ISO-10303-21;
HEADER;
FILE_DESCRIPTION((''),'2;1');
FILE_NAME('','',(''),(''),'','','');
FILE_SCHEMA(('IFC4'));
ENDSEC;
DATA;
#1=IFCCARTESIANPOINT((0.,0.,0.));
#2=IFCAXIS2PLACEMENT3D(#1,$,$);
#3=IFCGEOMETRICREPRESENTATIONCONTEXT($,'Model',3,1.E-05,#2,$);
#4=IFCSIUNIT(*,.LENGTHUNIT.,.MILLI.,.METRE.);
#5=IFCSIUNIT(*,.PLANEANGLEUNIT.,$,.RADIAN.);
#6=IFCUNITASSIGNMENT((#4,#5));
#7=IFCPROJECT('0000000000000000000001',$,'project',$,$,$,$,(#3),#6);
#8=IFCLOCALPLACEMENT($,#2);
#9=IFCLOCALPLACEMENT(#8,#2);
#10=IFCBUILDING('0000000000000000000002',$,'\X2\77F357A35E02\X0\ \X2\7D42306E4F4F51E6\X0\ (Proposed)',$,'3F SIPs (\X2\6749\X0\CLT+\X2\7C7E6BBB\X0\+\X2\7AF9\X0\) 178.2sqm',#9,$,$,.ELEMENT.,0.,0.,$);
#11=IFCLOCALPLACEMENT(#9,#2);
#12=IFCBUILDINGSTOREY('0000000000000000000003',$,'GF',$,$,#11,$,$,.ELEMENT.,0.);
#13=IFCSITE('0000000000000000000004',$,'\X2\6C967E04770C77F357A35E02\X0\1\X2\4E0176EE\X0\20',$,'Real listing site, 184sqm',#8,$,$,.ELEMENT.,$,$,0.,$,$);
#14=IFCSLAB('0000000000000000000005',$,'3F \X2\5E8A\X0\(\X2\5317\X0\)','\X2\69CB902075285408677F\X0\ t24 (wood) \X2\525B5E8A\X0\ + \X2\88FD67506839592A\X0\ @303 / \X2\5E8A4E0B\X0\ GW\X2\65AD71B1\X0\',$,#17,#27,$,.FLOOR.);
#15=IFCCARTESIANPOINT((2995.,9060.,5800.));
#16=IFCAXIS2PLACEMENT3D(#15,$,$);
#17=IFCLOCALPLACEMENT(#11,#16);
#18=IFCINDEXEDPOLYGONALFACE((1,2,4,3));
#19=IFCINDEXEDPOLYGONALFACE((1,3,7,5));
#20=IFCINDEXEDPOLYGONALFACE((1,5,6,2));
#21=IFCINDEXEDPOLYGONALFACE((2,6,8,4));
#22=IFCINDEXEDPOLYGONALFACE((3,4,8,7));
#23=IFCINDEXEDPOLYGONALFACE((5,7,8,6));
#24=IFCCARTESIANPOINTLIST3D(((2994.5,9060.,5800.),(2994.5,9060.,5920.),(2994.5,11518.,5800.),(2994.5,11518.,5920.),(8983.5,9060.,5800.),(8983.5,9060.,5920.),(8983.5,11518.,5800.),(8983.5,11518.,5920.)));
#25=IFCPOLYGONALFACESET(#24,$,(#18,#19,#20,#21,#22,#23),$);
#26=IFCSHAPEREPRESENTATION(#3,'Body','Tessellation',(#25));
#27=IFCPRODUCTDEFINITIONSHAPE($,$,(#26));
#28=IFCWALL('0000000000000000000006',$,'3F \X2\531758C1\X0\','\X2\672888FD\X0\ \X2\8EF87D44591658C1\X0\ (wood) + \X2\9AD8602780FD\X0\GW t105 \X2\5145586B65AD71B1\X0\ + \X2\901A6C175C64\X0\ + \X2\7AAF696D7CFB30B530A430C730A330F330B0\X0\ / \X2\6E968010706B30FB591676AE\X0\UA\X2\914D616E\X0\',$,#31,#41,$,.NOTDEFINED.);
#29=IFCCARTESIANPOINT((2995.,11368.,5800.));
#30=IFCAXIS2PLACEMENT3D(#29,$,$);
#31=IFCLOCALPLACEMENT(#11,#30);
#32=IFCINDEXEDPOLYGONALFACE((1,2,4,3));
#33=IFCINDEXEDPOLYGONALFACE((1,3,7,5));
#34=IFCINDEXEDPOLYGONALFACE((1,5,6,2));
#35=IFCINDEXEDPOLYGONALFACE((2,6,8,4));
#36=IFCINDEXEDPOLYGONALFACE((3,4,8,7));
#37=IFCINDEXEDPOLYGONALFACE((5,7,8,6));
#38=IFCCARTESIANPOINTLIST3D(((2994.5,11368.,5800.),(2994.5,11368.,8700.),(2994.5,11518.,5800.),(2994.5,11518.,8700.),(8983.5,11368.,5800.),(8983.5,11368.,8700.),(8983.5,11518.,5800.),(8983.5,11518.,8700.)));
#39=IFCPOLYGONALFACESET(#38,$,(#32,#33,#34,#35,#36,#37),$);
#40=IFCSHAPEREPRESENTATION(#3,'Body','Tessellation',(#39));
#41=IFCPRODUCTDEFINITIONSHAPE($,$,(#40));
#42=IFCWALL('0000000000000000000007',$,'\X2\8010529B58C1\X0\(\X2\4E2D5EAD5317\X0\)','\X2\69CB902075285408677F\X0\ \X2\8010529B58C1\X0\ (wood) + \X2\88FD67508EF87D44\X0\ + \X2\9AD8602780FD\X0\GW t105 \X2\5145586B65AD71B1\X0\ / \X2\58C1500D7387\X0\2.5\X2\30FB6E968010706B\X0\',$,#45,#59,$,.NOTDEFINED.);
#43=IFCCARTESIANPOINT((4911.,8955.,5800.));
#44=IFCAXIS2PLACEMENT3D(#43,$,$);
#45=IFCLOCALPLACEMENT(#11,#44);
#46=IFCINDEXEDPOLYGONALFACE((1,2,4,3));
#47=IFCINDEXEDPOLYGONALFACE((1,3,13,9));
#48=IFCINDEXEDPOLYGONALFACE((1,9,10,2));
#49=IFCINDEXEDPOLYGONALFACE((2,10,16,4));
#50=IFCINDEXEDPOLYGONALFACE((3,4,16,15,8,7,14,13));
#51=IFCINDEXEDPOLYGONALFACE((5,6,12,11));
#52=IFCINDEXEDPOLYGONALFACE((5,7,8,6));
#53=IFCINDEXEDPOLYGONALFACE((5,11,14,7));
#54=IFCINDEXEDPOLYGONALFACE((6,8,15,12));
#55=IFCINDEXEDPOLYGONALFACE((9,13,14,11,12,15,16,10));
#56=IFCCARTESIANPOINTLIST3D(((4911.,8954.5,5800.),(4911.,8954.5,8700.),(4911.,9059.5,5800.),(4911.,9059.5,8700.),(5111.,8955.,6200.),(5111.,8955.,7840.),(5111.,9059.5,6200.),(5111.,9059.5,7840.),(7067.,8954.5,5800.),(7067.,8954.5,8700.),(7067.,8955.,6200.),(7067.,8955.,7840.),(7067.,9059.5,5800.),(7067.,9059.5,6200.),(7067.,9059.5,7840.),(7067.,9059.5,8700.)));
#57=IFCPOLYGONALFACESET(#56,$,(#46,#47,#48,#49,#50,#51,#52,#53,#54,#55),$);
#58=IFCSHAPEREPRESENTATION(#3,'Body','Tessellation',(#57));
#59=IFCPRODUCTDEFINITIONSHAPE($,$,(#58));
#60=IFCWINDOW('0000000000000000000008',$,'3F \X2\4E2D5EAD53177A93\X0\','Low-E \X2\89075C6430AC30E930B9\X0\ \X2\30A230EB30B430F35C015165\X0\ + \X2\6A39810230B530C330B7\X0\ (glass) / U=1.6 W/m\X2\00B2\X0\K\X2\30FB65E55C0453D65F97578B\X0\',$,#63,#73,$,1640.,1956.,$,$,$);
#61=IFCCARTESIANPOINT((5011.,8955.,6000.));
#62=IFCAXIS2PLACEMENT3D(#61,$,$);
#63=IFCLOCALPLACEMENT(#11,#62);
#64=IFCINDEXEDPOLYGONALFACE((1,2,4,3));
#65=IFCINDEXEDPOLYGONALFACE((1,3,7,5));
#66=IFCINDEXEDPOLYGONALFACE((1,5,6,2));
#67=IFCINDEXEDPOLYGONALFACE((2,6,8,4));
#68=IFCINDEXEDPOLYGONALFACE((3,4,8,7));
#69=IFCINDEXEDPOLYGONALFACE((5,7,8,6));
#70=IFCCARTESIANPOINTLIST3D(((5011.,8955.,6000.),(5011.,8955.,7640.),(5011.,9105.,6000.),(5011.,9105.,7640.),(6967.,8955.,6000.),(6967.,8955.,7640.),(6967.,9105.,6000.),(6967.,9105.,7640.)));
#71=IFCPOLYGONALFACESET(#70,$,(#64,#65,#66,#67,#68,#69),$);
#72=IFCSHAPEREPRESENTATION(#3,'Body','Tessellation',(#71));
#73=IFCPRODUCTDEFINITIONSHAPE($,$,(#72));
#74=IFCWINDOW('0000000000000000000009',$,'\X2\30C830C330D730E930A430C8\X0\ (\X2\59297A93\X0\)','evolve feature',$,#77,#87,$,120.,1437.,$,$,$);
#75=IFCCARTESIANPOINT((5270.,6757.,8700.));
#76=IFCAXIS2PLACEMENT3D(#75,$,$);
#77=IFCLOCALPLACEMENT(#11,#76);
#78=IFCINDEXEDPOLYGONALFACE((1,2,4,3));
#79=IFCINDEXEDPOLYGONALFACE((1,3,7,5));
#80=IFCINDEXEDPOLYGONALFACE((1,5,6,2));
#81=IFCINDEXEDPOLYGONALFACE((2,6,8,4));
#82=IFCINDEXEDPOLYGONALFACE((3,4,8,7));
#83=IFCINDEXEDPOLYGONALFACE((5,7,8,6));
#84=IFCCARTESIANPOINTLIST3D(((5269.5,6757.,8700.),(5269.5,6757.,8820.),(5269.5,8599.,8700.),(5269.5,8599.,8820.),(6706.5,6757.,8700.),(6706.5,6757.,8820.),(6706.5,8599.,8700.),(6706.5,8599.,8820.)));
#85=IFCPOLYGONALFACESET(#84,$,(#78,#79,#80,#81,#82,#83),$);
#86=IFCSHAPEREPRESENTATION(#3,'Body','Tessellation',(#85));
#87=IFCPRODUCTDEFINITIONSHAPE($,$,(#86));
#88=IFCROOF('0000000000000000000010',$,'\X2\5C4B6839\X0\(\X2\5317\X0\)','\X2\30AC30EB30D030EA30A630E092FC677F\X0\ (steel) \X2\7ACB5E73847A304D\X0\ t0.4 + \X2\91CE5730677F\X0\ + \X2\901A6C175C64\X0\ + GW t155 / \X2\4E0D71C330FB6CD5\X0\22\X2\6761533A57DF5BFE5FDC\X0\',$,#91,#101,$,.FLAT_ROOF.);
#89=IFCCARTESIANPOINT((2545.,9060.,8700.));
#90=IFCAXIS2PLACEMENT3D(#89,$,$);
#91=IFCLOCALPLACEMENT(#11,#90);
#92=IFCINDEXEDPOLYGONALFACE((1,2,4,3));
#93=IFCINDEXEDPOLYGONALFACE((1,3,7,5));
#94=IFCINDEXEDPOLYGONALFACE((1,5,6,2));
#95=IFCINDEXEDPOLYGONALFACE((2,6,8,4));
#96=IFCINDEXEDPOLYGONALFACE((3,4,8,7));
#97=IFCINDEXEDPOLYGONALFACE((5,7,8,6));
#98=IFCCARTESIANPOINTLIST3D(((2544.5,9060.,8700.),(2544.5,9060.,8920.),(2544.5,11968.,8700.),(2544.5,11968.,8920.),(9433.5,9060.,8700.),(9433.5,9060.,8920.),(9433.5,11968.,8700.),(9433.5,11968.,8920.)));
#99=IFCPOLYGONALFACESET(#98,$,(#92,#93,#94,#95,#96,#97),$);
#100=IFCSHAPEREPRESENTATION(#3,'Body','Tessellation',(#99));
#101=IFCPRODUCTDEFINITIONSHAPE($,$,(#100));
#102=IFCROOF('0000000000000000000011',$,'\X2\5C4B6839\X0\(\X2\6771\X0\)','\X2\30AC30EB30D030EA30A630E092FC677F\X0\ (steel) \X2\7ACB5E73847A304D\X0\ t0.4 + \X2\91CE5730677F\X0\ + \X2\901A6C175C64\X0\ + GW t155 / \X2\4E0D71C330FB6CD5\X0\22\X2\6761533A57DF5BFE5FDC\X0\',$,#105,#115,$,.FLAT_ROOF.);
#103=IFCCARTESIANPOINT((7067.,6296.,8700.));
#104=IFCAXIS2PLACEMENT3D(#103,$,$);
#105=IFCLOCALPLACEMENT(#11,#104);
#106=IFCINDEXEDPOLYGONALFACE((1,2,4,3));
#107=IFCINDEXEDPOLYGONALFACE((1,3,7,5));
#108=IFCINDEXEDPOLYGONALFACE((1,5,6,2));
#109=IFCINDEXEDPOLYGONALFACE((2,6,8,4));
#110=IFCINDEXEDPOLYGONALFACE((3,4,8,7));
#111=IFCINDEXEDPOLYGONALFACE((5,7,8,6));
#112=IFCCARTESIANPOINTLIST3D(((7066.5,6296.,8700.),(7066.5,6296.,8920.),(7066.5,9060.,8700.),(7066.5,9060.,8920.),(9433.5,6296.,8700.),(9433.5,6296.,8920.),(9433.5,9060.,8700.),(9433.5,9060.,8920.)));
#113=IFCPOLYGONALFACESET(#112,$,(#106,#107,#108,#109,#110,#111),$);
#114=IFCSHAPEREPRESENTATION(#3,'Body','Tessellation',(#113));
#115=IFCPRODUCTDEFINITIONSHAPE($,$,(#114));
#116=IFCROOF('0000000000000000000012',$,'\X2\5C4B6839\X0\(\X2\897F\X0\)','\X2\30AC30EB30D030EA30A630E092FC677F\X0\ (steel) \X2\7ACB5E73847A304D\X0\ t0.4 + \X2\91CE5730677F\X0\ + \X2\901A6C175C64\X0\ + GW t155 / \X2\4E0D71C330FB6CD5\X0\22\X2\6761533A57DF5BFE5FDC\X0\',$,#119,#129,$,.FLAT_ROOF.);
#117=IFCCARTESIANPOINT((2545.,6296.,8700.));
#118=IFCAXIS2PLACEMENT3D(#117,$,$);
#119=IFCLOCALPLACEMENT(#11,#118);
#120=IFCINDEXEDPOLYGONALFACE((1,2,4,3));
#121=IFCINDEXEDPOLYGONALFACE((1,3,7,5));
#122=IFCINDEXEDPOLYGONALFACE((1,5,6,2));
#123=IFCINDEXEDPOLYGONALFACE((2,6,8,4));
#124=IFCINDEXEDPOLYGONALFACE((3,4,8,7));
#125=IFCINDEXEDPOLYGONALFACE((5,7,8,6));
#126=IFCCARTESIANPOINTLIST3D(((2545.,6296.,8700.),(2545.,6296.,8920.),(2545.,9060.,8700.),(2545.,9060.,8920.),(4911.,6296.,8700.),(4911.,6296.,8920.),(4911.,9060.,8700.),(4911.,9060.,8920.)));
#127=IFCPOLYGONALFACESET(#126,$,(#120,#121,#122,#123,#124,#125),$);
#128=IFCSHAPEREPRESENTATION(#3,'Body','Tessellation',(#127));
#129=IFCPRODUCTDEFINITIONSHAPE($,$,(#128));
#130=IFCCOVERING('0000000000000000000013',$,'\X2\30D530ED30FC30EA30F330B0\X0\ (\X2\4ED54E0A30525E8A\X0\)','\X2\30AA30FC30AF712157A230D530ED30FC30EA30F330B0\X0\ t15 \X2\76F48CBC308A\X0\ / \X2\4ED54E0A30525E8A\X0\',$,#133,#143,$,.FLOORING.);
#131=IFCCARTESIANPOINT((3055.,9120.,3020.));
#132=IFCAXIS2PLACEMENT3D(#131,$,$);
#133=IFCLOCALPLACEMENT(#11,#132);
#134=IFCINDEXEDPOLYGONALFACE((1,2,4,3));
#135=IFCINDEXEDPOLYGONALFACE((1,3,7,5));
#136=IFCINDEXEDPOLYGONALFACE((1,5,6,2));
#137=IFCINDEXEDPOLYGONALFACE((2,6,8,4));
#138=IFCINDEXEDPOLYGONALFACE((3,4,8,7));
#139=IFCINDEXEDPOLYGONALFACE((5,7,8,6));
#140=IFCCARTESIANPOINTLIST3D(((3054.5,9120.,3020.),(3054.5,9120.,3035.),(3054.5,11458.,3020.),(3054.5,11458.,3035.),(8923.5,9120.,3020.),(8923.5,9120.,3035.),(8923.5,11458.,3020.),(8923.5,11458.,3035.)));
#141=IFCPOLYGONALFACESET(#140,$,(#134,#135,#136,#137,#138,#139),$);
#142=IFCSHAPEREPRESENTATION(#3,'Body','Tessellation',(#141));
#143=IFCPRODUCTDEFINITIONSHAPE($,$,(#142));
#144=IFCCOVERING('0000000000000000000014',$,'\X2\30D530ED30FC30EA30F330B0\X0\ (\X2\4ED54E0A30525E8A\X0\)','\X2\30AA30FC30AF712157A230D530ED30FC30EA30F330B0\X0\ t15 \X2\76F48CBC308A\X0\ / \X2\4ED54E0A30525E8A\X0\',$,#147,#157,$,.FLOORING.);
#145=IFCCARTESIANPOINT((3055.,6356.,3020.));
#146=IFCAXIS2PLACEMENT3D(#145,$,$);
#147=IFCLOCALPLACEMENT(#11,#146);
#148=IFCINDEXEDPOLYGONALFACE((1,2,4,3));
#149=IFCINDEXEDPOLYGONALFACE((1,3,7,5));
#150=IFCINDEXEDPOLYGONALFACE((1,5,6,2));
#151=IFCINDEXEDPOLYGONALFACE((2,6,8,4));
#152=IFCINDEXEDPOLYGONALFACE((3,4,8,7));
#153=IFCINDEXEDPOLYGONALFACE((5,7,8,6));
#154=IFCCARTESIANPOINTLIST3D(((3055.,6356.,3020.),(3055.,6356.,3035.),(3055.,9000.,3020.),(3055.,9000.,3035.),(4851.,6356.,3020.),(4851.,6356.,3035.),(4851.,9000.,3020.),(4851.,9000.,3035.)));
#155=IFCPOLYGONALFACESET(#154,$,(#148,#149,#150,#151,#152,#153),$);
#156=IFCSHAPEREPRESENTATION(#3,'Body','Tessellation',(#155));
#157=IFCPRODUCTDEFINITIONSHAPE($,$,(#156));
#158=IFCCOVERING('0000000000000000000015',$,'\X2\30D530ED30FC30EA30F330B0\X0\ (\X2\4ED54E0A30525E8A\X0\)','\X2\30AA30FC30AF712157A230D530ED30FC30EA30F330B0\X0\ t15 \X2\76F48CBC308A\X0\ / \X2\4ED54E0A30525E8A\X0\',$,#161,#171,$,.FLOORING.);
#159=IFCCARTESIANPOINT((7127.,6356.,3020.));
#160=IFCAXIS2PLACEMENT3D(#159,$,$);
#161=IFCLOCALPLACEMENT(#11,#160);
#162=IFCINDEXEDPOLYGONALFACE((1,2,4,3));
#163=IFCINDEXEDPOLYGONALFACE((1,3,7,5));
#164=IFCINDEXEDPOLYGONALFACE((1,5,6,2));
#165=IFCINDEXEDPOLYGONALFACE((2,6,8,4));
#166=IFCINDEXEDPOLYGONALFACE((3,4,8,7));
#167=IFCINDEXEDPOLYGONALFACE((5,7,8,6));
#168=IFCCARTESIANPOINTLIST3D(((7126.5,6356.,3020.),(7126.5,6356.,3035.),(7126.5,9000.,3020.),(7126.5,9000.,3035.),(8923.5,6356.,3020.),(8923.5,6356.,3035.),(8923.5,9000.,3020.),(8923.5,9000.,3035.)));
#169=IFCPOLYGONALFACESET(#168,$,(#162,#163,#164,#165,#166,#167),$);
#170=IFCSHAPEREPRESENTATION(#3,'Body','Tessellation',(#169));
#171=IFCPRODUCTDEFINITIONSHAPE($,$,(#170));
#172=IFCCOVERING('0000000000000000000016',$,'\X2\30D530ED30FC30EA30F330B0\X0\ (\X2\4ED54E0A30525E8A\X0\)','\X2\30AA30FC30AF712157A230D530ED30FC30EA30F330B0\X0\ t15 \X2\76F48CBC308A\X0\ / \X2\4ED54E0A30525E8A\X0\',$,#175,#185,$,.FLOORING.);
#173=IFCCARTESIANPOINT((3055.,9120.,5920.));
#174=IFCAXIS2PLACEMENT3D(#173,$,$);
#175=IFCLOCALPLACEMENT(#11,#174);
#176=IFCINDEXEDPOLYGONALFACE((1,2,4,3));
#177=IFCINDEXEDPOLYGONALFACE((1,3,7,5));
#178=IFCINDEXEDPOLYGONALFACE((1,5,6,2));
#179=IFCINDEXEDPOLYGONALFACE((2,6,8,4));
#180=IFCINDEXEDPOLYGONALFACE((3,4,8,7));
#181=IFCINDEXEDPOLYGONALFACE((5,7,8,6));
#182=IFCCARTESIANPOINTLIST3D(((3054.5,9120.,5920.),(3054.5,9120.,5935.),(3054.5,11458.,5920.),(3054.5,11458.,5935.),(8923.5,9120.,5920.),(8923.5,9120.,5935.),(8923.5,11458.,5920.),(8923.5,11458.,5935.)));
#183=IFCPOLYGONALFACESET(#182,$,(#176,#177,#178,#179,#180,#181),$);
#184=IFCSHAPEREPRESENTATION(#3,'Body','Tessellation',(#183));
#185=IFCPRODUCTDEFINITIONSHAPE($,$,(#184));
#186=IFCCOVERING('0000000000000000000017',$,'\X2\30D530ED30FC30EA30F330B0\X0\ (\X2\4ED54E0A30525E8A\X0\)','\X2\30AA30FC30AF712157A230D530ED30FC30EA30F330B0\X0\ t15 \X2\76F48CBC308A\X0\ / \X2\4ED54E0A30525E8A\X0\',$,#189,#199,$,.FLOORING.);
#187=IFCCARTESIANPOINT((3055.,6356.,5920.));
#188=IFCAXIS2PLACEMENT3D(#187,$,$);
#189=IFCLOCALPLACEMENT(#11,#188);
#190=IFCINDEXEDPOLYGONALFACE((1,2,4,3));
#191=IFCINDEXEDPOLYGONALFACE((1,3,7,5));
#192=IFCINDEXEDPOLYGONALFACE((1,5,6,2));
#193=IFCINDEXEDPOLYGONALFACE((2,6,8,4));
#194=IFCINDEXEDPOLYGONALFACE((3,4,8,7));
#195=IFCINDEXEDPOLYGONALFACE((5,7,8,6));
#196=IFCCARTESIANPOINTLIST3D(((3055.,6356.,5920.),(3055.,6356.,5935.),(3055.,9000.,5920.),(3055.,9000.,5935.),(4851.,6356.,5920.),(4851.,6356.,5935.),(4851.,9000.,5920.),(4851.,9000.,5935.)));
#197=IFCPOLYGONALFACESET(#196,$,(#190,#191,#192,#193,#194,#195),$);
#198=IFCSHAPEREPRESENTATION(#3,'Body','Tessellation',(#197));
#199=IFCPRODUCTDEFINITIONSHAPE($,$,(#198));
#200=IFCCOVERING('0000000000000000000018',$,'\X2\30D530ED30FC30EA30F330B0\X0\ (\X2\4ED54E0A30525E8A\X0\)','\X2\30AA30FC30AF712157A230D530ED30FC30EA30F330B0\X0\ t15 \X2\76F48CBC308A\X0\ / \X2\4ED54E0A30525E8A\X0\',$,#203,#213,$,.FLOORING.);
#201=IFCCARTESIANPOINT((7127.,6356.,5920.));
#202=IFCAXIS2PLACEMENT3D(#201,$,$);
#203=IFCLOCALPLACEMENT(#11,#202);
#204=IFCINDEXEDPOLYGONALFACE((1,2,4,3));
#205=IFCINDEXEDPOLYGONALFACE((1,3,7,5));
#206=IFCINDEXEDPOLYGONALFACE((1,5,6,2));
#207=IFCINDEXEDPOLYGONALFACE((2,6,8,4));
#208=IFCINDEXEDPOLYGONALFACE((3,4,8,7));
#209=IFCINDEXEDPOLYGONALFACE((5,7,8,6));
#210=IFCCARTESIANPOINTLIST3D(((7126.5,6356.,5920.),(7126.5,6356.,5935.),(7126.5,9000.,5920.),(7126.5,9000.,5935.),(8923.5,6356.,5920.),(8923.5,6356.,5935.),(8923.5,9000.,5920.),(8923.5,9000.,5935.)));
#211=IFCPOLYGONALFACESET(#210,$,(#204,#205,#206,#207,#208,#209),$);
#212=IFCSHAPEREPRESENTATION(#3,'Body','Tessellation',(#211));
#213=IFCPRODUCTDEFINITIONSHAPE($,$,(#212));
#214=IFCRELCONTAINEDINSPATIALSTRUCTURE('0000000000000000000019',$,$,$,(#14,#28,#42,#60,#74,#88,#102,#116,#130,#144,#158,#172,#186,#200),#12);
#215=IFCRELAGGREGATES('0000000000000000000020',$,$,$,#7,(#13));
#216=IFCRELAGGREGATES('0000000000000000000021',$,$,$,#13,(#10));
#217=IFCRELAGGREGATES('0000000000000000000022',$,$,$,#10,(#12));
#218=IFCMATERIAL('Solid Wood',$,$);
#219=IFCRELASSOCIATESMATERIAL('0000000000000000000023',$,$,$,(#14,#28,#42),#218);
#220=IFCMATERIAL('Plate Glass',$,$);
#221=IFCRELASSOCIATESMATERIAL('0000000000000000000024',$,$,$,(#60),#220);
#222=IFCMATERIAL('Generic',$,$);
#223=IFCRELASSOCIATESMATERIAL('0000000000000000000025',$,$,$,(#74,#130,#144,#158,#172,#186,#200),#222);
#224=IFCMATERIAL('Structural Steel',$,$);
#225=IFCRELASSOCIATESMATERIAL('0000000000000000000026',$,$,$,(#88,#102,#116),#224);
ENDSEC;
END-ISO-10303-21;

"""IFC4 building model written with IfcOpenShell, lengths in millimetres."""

from ifc_helpers import new_model, si_unit, frame, frame_2d, origin, place, context, project, spatial, rectangle, extrude, material, element, fill, save


model = new_model("IFC4")

# Units and contexts
model_context = context("Model", 3, precision=1e-05, world=origin())
ifc_project = project(units=[si_unit("LENGTHUNIT", "METRE", prefix="MILLI"), si_unit("PLANEANGLEUNIT", "RADIAN")], contexts=[model_context])

# Site, building, storey
site_placement = place(None, origin())
site = spatial("IfcSite", under=ifc_project, at=site_placement, Name="沖縄県石垣市1丁目20", ObjectType="Real listing site, 184sqm", CompositionType="ELEMENT", RefElevation=0.0)
building_placement = place(site_placement, origin())
building = spatial("IfcBuilding", under=site, at=building_placement, Name="石垣市 終の住処 (Proposed)", ObjectType="3F SIPs (杉CLT+籾殻+竹) 178.2sqm", CompositionType="ELEMENT", ElevationOfRefHeight=0.0, ElevationOfTerrain=0.0)
storey_placement = place(building_placement, origin())
storey = spatial("IfcBuildingStorey", under=building, at=storey_placement, Name="GF", CompositionType="ELEMENT", Elevation=0.0)

# Slab
ifc_material_1 = material(Name="Solid Wood")
slab_placement = place(storey_placement, frame((2995.0, 9060.0, 5800.0)))
element("IfcSlab", 1, at=slab_placement, inside=storey, material=ifc_material_1, Name="3F 床(北)", Description="構造用合板 t24 (wood) 剛床 + 製材根太 @303 / 床下 GW断熱", PredefinedType="FLOOR", context=model_context, shape_type="SweptSolid", body=[
    extrude(rectangle(XDim=5989.0, YDim=2458.0, at=frame_2d((2994.0, 1229.0))), frame((2995.0, 9060.0, 5800.0)), (0.0, 0.0, 1.0), 120.0),
])

# Wall
wall_1_placement = place(storey_placement, frame((2995.0, 11368.0, 5800.0)))
element("IfcWall", 2, at=wall_1_placement, inside=storey, material=ifc_material_1, Name="3F 北壁", Description="木製 軸組外壁 (wood) + 高性能GW t105 充填断熱 + 通気層 + 窯業系サイディング / 準耐火・外皮UA配慮", PredefinedType="NOTDEFINED", context=model_context, shape_type="SweptSolid", body=[
    extrude(rectangle(XDim=5989.0, YDim=150.0, at=frame_2d((2994.0, 75.0))), frame((2995.0, 11368.0, 5800.0)), (0.0, 0.0, 1.0), 2900.0),
])

# Wall, opening, window
wall_2_placement = place(storey_placement, frame((4911.0, 8955.0, 5800.0)))
wall_2 = element("IfcWall", 3, at=wall_2_placement, inside=storey, material=ifc_material_1, Name="耐力壁(中庭北)", Description="構造用合板 耐力壁 (wood) + 製材軸組 + 高性能GW t105 充填断熱 / 壁倍率2.5・準耐火", PredefinedType="NOTDEFINED", context=model_context, shape_type="SweptSolid", body=[
    extrude(rectangle(XDim=2156.0, YDim=105.0, at=frame_2d((1078.0, 52.0))), frame((4911.0, 8955.0, 5800.0)), (0.0, 0.0, 1.0), 2900.0),
])
opening_placement = place(storey_placement, frame((5011.0, 8955.0, 6000.0)))
opening = element("IfcOpeningElement", 4, at=opening_placement, cuts=wall_2, PredefinedType="NOTDEFINED", context=model_context, shape_type="SweptSolid", body=[
    extrude(rectangle(XDim=1956.0, YDim=150.0, at=frame_2d((978.0, 75.0))), frame((5011.0, 8955.0, 6000.0)), (0.0, 0.0, 1.0), 1640.0),
])
ifc_material_2 = material(Name="Plate Glass")
window_1_placement = place(storey_placement, frame((5011.0, 8955.0, 6000.0)))
window_1 = element("IfcWindow", 5, at=window_1_placement, inside=storey, material=ifc_material_2, Name="3F 中庭北窓", Description="Low-E 複層ガラス アルゴン封入 + 樹脂サッシ (glass) / U=1.6 W/m²K・日射取得型", OverallHeight=1640.0, OverallWidth=1956.0, context=model_context, shape_type="SweptSolid", body=[
    extrude(rectangle(XDim=1956.0, YDim=150.0, at=frame_2d((978.0, 75.0))), frame((5011.0, 8955.0, 6000.0)), (0.0, 0.0, 1.0), 1640.0),
])
fill(opening, window_1)

# Window
ifc_material_3 = material(Name="Generic")
window_2_placement = place(storey_placement, frame((5270.0, 6757.0, 8700.0)))
element("IfcWindow", 6, at=window_2_placement, inside=storey, material=ifc_material_3, Name="トップライト (天窓)", Description="evolve feature", OverallHeight=120.0, OverallWidth=1437.0, context=model_context, shape_type="SweptSolid", body=[
    extrude(rectangle(XDim=1437.0, YDim=1842.0, at=frame_2d((718.0, 921.0))), frame((5270.0, 6757.0, 8700.0)), (0.0, 0.0, 1.0), 120.0),
])

# Roofs
ifc_material_4 = material(Name="Structural Steel")
roof_1_placement = place(storey_placement, frame((2545.0, 9060.0, 8700.0)))
element("IfcRoof", 7, at=roof_1_placement, inside=storey, material=ifc_material_4, Name="屋根(北)", Description="ガルバリウム鋼板 (steel) 立平葺き t0.4 + 野地板 + 通気層 + GW t155 / 不燃・法22条区域対応", PredefinedType="FLAT_ROOF", context=model_context, shape_type="SweptSolid", body=[
    extrude(rectangle(XDim=6889.0, YDim=2908.0, at=frame_2d((3444.0, 1454.0))), frame((2545.0, 9060.0, 8700.0)), (0.0, 0.0, 1.0), 220.0),
])
roof_2_placement = place(storey_placement, frame((7067.0, 6296.0, 8700.0)))
element("IfcRoof", 8, at=roof_2_placement, inside=storey, material=ifc_material_4, Name="屋根(東)", Description="ガルバリウム鋼板 (steel) 立平葺き t0.4 + 野地板 + 通気層 + GW t155 / 不燃・法22条区域対応", PredefinedType="FLAT_ROOF", context=model_context, shape_type="SweptSolid", body=[
    extrude(rectangle(XDim=2367.0, YDim=2764.0, at=frame_2d((1183.0, 1382.0))), frame((7067.0, 6296.0, 8700.0)), (0.0, 0.0, 1.0), 220.0),
])
roof_3_placement = place(storey_placement, frame((2545.0, 6296.0, 8700.0)))
element("IfcRoof", 9, at=roof_3_placement, inside=storey, material=ifc_material_4, Name="屋根(西)", Description="ガルバリウム鋼板 (steel) 立平葺き t0.4 + 野地板 + 通気層 + GW t155 / 不燃・法22条区域対応", PredefinedType="FLAT_ROOF", context=model_context, shape_type="SweptSolid", body=[
    extrude(rectangle(XDim=2366.0, YDim=2764.0, at=frame_2d((1183.0, 1382.0))), frame((2545.0, 6296.0, 8700.0)), (0.0, 0.0, 1.0), 220.0),
])

# Coverings
covering_1_placement = place(storey_placement, frame((3055.0, 9120.0, 3020.0)))
element("IfcCovering", 10, at=covering_1_placement, inside=storey, material=ifc_material_3, Name="フローリング (仕上げ床)", Description="オーク無垢フローリング t15 直貼り / 仕上げ床", PredefinedType="FLOORING", context=model_context, shape_type="SweptSolid", body=[
    extrude(rectangle(XDim=5869.0, YDim=2338.0, at=frame_2d((2934.0, 1169.0))), frame((3055.0, 9120.0, 3020.0)), (0.0, 0.0, 1.0), 15.0),
])
covering_2_placement = place(storey_placement, frame((3055.0, 6356.0, 3020.0)))
element("IfcCovering", 11, at=covering_2_placement, inside=storey, material=ifc_material_3, Name="フローリング (仕上げ床)", Description="オーク無垢フローリング t15 直貼り / 仕上げ床", PredefinedType="FLOORING", context=model_context, shape_type="SweptSolid", body=[
    extrude(rectangle(XDim=1796.0, YDim=2644.0, at=frame_2d((898.0, 1322.0))), frame((3055.0, 6356.0, 3020.0)), (0.0, 0.0, 1.0), 15.0),
])
covering_3_placement = place(storey_placement, frame((7127.0, 6356.0, 3020.0)))
element("IfcCovering", 12, at=covering_3_placement, inside=storey, material=ifc_material_3, Name="フローリング (仕上げ床)", Description="オーク無垢フローリング t15 直貼り / 仕上げ床", PredefinedType="FLOORING", context=model_context, shape_type="SweptSolid", body=[
    extrude(rectangle(XDim=1797.0, YDim=2644.0, at=frame_2d((898.0, 1322.0))), frame((7127.0, 6356.0, 3020.0)), (0.0, 0.0, 1.0), 15.0),
])
covering_4_placement = place(storey_placement, frame((3055.0, 9120.0, 5920.0)))
element("IfcCovering", 13, at=covering_4_placement, inside=storey, material=ifc_material_3, Name="フローリング (仕上げ床)", Description="オーク無垢フローリング t15 直貼り / 仕上げ床", PredefinedType="FLOORING", context=model_context, shape_type="SweptSolid", body=[
    extrude(rectangle(XDim=5869.0, YDim=2338.0, at=frame_2d((2934.0, 1169.0))), frame((3055.0, 9120.0, 5920.0)), (0.0, 0.0, 1.0), 15.0),
])
covering_5_placement = place(storey_placement, frame((3055.0, 6356.0, 5920.0)))
element("IfcCovering", 14, at=covering_5_placement, inside=storey, material=ifc_material_3, Name="フローリング (仕上げ床)", Description="オーク無垢フローリング t15 直貼り / 仕上げ床", PredefinedType="FLOORING", context=model_context, shape_type="SweptSolid", body=[
    extrude(rectangle(XDim=1796.0, YDim=2644.0, at=frame_2d((898.0, 1322.0))), frame((3055.0, 6356.0, 5920.0)), (0.0, 0.0, 1.0), 15.0),
])
covering_6_placement = place(storey_placement, frame((7127.0, 6356.0, 5920.0)))
element("IfcCovering", 15, at=covering_6_placement, inside=storey, material=ifc_material_3, Name="フローリング (仕上げ床)", Description="オーク無垢フローリング t15 直貼り / 仕上げ床", PredefinedType="FLOORING", context=model_context, shape_type="SweptSolid", body=[
    extrude(rectangle(XDim=1797.0, YDim=2644.0, at=frame_2d((898.0, 1322.0))), frame((7127.0, 6356.0, 5920.0)), (0.0, 0.0, 1.0), 15.0),
])

save(model, "model.ifc")
